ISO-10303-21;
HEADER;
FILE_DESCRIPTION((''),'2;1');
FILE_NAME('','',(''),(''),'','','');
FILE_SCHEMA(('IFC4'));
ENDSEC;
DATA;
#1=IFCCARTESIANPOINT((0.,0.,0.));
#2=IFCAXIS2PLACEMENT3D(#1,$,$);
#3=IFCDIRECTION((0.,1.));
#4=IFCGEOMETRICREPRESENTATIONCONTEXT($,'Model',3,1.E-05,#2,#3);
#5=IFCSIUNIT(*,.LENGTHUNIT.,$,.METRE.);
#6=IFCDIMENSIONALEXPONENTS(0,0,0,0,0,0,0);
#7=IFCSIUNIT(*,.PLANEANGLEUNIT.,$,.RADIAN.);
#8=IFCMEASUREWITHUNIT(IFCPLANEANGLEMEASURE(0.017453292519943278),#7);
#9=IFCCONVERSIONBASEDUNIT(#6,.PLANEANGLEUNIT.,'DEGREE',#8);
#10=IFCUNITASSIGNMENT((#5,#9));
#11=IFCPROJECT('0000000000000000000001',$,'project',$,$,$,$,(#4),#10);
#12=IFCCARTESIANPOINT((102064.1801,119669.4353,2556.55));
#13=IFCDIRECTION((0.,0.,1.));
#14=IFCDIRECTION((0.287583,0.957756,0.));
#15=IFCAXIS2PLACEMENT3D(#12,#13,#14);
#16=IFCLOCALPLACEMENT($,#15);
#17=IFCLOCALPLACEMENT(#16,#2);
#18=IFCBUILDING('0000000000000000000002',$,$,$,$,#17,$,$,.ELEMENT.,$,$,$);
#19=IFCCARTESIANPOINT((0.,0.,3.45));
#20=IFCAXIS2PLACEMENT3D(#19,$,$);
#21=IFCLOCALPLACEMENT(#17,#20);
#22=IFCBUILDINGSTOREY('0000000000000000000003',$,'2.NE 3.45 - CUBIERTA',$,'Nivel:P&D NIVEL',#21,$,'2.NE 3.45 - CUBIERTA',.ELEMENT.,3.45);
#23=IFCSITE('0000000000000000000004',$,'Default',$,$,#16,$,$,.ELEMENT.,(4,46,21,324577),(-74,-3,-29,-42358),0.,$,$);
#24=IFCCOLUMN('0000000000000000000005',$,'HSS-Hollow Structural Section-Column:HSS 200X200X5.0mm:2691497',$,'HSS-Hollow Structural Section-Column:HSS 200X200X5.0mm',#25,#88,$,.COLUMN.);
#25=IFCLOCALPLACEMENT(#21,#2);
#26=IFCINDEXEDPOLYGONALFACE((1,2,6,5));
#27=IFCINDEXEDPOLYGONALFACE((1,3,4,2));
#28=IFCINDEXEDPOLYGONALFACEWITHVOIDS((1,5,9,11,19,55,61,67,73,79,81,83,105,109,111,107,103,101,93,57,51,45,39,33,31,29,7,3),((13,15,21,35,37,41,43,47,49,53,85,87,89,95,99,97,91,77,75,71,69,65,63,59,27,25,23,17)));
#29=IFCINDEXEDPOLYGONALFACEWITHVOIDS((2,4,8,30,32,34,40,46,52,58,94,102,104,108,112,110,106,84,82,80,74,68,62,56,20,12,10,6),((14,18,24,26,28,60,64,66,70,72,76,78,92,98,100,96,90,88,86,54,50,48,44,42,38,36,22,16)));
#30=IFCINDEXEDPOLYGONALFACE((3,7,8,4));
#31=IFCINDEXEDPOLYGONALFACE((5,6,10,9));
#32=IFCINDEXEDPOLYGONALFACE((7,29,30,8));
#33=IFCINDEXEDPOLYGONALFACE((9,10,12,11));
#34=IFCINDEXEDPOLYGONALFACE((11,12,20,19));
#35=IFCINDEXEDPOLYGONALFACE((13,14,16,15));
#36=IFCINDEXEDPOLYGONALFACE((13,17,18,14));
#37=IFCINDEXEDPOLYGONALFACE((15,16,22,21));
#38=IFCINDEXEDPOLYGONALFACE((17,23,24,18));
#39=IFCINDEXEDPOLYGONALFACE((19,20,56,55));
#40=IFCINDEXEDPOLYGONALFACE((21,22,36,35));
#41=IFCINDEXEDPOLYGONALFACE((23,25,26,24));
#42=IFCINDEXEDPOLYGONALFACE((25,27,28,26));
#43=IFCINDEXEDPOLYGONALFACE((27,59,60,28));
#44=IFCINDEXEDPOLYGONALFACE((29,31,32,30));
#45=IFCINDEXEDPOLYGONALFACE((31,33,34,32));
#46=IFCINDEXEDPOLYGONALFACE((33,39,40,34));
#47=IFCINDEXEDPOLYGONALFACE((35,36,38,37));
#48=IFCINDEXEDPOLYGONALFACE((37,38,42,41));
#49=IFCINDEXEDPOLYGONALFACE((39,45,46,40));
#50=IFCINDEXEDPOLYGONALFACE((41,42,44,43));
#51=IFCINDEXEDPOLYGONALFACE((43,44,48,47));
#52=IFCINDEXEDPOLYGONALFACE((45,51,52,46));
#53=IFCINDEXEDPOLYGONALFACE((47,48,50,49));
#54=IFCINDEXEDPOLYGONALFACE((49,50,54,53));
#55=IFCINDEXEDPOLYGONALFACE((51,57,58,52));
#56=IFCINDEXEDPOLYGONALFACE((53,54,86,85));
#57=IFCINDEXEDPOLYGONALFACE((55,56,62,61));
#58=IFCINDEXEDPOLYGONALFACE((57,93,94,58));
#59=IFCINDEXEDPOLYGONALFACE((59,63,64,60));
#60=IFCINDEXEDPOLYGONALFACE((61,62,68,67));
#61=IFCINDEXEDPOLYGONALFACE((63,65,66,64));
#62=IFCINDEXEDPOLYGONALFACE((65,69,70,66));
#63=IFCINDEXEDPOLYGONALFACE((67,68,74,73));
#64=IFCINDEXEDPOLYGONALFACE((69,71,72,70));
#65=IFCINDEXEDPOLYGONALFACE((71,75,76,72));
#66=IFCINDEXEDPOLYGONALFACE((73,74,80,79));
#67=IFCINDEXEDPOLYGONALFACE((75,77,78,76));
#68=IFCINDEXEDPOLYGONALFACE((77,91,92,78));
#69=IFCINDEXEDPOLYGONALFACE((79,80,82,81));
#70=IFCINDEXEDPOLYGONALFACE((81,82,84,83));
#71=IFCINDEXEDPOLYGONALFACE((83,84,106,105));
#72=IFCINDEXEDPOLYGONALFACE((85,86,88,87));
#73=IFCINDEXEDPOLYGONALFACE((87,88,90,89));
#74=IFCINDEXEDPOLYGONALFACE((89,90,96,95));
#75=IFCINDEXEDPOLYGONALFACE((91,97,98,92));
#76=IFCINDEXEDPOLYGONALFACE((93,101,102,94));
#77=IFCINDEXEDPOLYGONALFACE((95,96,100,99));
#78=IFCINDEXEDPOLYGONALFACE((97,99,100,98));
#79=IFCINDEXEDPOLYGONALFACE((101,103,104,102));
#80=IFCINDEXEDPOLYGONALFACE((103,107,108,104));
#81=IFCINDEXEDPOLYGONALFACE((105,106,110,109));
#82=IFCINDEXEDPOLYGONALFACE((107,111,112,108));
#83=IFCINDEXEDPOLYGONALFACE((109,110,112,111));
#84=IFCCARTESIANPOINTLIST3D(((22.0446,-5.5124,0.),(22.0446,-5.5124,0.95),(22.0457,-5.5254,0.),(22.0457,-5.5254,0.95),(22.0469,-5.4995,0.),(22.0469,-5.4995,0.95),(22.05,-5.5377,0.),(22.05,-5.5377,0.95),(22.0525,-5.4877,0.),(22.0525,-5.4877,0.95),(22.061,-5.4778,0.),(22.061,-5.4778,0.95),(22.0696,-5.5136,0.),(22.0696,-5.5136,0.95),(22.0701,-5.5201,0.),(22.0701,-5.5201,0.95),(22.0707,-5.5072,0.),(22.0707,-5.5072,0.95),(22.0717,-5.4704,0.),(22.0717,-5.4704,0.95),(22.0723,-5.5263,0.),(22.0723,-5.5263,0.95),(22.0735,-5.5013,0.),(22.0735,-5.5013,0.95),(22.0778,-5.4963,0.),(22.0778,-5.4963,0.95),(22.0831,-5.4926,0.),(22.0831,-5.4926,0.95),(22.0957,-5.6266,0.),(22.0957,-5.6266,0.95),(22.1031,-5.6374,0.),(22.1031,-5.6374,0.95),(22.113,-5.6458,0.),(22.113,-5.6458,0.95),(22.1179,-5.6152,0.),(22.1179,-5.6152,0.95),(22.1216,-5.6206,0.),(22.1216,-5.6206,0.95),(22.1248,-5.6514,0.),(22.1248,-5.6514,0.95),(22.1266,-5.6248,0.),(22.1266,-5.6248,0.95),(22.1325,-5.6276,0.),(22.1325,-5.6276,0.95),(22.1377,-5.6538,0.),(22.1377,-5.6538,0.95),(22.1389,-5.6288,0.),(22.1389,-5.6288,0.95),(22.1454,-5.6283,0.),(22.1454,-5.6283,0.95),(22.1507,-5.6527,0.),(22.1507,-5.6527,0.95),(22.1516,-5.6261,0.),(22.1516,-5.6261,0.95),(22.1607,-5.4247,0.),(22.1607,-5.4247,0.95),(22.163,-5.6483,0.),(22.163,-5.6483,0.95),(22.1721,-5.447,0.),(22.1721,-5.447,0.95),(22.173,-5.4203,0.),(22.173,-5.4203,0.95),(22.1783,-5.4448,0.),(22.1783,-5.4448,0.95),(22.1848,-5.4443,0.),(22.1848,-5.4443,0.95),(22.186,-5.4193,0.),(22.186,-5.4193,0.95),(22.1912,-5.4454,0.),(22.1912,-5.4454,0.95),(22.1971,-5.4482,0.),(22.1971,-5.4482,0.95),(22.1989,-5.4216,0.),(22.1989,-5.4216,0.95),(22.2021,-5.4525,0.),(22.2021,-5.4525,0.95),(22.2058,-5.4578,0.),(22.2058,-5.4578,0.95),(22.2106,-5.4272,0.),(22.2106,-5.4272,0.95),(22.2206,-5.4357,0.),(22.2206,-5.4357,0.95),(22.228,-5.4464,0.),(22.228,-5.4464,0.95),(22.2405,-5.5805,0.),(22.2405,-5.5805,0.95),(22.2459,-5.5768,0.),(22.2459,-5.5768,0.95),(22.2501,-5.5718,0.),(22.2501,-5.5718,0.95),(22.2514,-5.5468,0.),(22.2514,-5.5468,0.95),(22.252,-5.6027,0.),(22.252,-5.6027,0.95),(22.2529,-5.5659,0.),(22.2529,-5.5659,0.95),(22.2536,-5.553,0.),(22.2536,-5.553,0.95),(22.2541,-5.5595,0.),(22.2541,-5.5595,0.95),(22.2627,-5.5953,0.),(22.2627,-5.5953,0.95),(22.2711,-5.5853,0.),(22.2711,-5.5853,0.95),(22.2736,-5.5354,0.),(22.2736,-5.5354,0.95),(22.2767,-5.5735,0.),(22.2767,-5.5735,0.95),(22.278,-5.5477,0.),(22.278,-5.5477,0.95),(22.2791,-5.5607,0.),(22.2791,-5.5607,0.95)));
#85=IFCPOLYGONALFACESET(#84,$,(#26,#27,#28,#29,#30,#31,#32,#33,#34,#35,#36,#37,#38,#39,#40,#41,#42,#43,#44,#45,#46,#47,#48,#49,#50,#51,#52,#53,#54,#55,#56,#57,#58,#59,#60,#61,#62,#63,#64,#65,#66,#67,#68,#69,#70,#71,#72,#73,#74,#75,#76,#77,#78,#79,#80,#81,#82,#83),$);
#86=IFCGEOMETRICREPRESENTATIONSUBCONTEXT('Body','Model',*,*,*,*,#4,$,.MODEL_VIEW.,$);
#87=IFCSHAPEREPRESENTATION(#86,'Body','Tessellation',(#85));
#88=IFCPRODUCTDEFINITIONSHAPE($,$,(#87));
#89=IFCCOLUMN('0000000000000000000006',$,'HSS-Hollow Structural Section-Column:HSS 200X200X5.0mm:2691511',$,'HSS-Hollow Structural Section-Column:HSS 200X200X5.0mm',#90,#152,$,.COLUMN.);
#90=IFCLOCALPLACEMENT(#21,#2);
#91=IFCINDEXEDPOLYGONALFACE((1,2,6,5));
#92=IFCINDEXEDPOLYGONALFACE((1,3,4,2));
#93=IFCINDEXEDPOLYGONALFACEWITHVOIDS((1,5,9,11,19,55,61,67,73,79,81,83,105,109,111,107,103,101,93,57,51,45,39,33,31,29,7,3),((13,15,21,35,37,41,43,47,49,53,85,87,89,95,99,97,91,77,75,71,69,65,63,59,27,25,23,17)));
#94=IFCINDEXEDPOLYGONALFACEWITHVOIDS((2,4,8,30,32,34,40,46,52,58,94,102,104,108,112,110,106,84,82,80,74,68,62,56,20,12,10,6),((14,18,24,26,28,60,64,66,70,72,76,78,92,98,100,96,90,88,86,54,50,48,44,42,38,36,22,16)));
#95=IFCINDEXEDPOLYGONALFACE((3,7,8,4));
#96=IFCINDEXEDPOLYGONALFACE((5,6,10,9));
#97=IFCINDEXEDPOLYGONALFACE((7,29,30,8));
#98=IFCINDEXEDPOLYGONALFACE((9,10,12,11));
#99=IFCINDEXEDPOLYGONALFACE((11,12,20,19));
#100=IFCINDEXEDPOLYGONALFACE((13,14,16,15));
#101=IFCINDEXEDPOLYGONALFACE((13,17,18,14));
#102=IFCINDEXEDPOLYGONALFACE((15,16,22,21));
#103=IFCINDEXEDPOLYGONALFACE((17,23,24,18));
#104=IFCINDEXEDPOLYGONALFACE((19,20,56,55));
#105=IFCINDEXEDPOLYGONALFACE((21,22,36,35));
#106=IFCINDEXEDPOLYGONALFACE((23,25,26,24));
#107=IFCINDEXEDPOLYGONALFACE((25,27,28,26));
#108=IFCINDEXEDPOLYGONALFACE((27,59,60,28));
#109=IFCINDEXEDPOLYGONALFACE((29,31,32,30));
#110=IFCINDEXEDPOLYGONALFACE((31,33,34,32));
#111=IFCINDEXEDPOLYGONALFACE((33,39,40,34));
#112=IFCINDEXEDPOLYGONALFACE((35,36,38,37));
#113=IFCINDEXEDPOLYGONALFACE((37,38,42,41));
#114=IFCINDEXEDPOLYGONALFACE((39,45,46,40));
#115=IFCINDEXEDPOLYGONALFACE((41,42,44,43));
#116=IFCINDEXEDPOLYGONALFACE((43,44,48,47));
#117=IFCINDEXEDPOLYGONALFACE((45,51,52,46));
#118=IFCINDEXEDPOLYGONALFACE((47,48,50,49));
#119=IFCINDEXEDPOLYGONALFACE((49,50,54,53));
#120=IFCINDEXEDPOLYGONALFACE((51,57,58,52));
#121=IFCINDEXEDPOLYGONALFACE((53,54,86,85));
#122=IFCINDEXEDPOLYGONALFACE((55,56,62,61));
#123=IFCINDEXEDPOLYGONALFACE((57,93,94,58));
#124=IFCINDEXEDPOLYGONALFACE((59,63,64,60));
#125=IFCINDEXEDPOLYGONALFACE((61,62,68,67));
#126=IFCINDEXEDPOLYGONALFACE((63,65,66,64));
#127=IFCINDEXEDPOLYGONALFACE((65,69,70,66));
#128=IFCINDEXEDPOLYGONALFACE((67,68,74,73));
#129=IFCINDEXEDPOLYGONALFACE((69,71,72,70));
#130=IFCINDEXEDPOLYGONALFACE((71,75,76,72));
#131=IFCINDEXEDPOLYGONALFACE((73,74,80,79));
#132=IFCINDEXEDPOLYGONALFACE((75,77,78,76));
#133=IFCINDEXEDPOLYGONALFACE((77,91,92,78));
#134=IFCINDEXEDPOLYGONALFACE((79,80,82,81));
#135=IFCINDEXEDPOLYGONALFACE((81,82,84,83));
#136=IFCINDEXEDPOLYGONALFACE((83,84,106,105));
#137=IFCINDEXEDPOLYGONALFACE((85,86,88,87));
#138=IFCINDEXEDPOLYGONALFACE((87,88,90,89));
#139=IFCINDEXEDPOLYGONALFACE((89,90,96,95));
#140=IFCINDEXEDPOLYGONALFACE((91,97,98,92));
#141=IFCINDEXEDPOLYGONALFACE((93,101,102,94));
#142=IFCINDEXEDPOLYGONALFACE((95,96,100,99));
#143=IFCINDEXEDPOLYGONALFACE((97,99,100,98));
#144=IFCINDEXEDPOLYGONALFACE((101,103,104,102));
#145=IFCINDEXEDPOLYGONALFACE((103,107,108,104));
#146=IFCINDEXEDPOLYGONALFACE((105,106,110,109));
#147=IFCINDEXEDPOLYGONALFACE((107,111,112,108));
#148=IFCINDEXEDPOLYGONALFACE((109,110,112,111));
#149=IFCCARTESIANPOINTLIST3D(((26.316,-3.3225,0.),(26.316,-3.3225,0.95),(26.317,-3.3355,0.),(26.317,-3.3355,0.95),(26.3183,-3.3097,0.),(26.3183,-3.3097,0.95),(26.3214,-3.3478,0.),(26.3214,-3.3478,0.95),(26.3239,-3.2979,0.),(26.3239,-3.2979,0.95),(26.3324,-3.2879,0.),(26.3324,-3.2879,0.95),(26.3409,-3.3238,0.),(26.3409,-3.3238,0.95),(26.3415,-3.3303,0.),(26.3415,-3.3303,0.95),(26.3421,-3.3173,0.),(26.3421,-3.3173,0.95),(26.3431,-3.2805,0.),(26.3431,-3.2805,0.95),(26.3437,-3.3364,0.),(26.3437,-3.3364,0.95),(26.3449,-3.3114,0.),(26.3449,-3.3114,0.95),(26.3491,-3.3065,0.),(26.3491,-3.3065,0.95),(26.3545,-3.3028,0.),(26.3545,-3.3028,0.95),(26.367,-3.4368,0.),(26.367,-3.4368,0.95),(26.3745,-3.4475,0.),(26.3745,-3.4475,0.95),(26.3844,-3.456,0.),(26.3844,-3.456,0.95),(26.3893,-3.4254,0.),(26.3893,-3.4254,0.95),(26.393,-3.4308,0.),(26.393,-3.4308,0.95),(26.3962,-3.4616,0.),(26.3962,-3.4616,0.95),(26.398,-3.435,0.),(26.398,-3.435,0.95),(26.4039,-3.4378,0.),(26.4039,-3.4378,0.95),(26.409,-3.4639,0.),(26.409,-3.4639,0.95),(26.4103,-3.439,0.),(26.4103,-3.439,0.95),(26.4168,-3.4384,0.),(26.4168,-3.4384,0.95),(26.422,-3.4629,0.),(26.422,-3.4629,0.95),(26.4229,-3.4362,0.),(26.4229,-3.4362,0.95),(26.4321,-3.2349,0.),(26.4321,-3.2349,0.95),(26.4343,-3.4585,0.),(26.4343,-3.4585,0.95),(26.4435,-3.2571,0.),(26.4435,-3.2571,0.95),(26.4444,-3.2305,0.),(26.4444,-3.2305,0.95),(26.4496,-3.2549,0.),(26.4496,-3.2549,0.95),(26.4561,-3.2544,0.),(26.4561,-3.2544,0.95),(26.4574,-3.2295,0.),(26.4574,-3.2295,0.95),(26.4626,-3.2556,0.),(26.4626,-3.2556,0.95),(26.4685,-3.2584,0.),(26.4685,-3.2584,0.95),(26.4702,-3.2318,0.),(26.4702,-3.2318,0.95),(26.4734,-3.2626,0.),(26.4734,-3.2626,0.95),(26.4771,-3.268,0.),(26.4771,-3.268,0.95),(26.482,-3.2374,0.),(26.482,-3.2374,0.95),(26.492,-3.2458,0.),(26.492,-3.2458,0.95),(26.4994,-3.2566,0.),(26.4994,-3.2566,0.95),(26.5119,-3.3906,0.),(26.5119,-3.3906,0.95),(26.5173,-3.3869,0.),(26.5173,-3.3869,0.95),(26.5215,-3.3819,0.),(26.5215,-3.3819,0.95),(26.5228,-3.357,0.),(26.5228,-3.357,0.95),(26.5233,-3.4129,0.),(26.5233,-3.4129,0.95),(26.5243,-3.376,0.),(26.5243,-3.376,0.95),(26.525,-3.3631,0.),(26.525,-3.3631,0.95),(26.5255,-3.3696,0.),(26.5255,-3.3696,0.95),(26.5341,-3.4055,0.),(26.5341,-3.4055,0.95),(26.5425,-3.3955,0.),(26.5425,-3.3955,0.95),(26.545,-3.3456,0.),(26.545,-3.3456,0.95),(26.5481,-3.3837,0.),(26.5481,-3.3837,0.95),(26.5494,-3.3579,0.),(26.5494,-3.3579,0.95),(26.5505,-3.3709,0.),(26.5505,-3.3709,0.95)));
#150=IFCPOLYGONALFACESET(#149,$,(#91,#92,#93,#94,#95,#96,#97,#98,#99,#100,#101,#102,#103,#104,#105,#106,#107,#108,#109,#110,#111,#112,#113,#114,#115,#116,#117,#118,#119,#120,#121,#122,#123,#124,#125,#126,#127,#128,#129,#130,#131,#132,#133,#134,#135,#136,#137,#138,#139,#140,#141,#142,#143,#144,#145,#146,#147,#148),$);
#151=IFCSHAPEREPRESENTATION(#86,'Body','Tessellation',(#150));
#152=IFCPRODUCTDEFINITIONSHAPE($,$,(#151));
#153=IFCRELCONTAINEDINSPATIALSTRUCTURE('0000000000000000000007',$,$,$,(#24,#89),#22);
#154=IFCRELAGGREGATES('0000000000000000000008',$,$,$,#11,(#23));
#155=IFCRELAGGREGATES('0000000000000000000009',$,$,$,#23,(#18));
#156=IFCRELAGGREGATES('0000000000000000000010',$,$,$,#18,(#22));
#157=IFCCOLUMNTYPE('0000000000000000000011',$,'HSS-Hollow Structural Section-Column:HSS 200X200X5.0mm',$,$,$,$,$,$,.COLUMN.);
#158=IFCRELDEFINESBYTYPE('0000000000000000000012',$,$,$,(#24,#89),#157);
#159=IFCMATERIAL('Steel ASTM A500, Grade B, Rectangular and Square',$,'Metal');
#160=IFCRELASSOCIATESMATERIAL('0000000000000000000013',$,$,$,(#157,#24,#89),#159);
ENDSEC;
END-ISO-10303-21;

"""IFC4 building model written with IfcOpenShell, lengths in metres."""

from ifc_helpers import new_model, entity, si_unit, converted_unit, direction, frame, origin, place, context, subcontext, project, spatial, line, arc, indexed_curve, outline, extrude, source, transform, mapped, material, type_object, type_shapes, element, save


model = new_model("IFC4")

# Units and contexts
model_context = context("Model", 3, precision=1e-05, world=origin(), true_north=direction((0.0, 1.0)))
body_context = subcontext(model_context, "Body", "Model", "MODEL_VIEW")
ifc_project = project(units=[si_unit("LENGTHUNIT", "METRE"), converted_unit("PLANEANGLEUNIT", "DEGREE", entity("IfcPlaneAngleMeasure", 0.017453292519943278), si_unit("PLANEANGLEUNIT", "RADIAN"), dimensions=[0, 0, 0, 0, 0, 0, 0])], contexts=[model_context])

# Site, building, storey
site_placement = place(None, frame((102064.1801, 119669.4353, 2556.55), z_axis=(0.0, 0.0, 1.0), x_axis=(0.287583, 0.957756, 0.0)))
site = spatial("IfcSite", under=ifc_project, at=site_placement, Name="Default", CompositionType="ELEMENT", RefLatitude=(4, 46, 21, 324577), RefLongitude=(-74, -3, -29, -42358), RefElevation=0.0)
building_placement = place(site_placement, origin())
building = spatial("IfcBuilding", under=site, at=building_placement, CompositionType="ELEMENT")
storey_placement = place(building_placement, frame((0.0, 0.0, 3.45)))
storey = spatial("IfcBuildingStorey", under=building, at=storey_placement, Name="2.NE 3.45 - CUBIERTA", ObjectType="Nivel:P&D NIVEL", LongName="2.NE 3.45 - CUBIERTA", CompositionType="ELEMENT", Elevation=3.45)

# Columns
ifc_material_1 = material(Name="Steel ASTM A500, Grade B, Rectangular and Square", Category="Metal")
column_type_1 = type_object("IfcColumnType", Name="HSS-Hollow Structural Section-Column:HSS 200X200X5.0mm", PredefinedType="COLUMN", material=ifc_material_1)
shared_shape_1 = source(origin(), body_context, "Body", "SweptSolid", [
    extrude(outline(indexed_curve([(-0.05, -0.1), (0.05, -0.1), (0.0854, -0.0854), (0.1, -0.05), (0.1, 0.05), (0.0854, 0.0854), (0.05, 0.1), (-0.05, 0.1), (-0.0854, 0.0854), (-0.1, 0.05), (-0.1, -0.05), (-0.0854, -0.0854)], segments=[line(1, 2), arc(2, 3, 4), line(4, 5), arc(5, 6, 7), line(7, 8), arc(8, 9, 10), line(10, 11), arc(11, 12, 1)], self_intersect=False), holes=[indexed_curve([(-0.05, -0.075), (-0.0677, -0.0677), (-0.075, -0.05), (-0.075, 0.05), (-0.0677, 0.0677), (-0.05, 0.075), (0.05, 0.075), (0.0677, 0.0677), (0.075, 0.05), (0.075, -0.05), (0.0677, -0.0677), (0.05, -0.075)], segments=[arc(1, 2, 3), line(3, 4), arc(4, 5, 6), line(6, 7), arc(7, 8, 9), line(9, 10), arc(10, 11, 12), line(12, 1)], self_intersect=False)]), frame((0.0, 0.0, 3.45), z_axis=(0.0, 0.0, 1.0), x_axis=(-1.0, 0.0, 0.0)), (0.0, 0.0, 1.0), 0.95),
])
type_shapes(column_type_1, [shared_shape_1])
for number, where, z_axis, x_axis, name in (
    (1, (22.1618, -5.5365, -3.45), (0.0, 0.0, 1.0), (0.889869, 0.456217, 0.0), "HSS-Hollow Structural Section-Column:HSS 200X200X5.0mm:2691497"),
    (2, (26.4332, -3.3467, -3.45), (0.0, 0.0, 1.0), (0.889869, 0.456217, 0.0), "HSS-Hollow Structural Section-Column:HSS 200X200X5.0mm:2691511"),
):
    element("IfcColumn", number, at=place(storey_placement, frame(where, z_axis=z_axis, x_axis=x_axis)), inside=storey, type_object=column_type_1, material=ifc_material_1, Name=name, ObjectType="HSS-Hollow Structural Section-Column:HSS 200X200X5.0mm", PredefinedType="COLUMN", context=body_context, shape_type="MappedRepresentation", body=[
        mapped(shared_shape_1, transform((0.0, 0.0, 0.0), scale=1.0)),
    ])

save(model, "model.ifc")
